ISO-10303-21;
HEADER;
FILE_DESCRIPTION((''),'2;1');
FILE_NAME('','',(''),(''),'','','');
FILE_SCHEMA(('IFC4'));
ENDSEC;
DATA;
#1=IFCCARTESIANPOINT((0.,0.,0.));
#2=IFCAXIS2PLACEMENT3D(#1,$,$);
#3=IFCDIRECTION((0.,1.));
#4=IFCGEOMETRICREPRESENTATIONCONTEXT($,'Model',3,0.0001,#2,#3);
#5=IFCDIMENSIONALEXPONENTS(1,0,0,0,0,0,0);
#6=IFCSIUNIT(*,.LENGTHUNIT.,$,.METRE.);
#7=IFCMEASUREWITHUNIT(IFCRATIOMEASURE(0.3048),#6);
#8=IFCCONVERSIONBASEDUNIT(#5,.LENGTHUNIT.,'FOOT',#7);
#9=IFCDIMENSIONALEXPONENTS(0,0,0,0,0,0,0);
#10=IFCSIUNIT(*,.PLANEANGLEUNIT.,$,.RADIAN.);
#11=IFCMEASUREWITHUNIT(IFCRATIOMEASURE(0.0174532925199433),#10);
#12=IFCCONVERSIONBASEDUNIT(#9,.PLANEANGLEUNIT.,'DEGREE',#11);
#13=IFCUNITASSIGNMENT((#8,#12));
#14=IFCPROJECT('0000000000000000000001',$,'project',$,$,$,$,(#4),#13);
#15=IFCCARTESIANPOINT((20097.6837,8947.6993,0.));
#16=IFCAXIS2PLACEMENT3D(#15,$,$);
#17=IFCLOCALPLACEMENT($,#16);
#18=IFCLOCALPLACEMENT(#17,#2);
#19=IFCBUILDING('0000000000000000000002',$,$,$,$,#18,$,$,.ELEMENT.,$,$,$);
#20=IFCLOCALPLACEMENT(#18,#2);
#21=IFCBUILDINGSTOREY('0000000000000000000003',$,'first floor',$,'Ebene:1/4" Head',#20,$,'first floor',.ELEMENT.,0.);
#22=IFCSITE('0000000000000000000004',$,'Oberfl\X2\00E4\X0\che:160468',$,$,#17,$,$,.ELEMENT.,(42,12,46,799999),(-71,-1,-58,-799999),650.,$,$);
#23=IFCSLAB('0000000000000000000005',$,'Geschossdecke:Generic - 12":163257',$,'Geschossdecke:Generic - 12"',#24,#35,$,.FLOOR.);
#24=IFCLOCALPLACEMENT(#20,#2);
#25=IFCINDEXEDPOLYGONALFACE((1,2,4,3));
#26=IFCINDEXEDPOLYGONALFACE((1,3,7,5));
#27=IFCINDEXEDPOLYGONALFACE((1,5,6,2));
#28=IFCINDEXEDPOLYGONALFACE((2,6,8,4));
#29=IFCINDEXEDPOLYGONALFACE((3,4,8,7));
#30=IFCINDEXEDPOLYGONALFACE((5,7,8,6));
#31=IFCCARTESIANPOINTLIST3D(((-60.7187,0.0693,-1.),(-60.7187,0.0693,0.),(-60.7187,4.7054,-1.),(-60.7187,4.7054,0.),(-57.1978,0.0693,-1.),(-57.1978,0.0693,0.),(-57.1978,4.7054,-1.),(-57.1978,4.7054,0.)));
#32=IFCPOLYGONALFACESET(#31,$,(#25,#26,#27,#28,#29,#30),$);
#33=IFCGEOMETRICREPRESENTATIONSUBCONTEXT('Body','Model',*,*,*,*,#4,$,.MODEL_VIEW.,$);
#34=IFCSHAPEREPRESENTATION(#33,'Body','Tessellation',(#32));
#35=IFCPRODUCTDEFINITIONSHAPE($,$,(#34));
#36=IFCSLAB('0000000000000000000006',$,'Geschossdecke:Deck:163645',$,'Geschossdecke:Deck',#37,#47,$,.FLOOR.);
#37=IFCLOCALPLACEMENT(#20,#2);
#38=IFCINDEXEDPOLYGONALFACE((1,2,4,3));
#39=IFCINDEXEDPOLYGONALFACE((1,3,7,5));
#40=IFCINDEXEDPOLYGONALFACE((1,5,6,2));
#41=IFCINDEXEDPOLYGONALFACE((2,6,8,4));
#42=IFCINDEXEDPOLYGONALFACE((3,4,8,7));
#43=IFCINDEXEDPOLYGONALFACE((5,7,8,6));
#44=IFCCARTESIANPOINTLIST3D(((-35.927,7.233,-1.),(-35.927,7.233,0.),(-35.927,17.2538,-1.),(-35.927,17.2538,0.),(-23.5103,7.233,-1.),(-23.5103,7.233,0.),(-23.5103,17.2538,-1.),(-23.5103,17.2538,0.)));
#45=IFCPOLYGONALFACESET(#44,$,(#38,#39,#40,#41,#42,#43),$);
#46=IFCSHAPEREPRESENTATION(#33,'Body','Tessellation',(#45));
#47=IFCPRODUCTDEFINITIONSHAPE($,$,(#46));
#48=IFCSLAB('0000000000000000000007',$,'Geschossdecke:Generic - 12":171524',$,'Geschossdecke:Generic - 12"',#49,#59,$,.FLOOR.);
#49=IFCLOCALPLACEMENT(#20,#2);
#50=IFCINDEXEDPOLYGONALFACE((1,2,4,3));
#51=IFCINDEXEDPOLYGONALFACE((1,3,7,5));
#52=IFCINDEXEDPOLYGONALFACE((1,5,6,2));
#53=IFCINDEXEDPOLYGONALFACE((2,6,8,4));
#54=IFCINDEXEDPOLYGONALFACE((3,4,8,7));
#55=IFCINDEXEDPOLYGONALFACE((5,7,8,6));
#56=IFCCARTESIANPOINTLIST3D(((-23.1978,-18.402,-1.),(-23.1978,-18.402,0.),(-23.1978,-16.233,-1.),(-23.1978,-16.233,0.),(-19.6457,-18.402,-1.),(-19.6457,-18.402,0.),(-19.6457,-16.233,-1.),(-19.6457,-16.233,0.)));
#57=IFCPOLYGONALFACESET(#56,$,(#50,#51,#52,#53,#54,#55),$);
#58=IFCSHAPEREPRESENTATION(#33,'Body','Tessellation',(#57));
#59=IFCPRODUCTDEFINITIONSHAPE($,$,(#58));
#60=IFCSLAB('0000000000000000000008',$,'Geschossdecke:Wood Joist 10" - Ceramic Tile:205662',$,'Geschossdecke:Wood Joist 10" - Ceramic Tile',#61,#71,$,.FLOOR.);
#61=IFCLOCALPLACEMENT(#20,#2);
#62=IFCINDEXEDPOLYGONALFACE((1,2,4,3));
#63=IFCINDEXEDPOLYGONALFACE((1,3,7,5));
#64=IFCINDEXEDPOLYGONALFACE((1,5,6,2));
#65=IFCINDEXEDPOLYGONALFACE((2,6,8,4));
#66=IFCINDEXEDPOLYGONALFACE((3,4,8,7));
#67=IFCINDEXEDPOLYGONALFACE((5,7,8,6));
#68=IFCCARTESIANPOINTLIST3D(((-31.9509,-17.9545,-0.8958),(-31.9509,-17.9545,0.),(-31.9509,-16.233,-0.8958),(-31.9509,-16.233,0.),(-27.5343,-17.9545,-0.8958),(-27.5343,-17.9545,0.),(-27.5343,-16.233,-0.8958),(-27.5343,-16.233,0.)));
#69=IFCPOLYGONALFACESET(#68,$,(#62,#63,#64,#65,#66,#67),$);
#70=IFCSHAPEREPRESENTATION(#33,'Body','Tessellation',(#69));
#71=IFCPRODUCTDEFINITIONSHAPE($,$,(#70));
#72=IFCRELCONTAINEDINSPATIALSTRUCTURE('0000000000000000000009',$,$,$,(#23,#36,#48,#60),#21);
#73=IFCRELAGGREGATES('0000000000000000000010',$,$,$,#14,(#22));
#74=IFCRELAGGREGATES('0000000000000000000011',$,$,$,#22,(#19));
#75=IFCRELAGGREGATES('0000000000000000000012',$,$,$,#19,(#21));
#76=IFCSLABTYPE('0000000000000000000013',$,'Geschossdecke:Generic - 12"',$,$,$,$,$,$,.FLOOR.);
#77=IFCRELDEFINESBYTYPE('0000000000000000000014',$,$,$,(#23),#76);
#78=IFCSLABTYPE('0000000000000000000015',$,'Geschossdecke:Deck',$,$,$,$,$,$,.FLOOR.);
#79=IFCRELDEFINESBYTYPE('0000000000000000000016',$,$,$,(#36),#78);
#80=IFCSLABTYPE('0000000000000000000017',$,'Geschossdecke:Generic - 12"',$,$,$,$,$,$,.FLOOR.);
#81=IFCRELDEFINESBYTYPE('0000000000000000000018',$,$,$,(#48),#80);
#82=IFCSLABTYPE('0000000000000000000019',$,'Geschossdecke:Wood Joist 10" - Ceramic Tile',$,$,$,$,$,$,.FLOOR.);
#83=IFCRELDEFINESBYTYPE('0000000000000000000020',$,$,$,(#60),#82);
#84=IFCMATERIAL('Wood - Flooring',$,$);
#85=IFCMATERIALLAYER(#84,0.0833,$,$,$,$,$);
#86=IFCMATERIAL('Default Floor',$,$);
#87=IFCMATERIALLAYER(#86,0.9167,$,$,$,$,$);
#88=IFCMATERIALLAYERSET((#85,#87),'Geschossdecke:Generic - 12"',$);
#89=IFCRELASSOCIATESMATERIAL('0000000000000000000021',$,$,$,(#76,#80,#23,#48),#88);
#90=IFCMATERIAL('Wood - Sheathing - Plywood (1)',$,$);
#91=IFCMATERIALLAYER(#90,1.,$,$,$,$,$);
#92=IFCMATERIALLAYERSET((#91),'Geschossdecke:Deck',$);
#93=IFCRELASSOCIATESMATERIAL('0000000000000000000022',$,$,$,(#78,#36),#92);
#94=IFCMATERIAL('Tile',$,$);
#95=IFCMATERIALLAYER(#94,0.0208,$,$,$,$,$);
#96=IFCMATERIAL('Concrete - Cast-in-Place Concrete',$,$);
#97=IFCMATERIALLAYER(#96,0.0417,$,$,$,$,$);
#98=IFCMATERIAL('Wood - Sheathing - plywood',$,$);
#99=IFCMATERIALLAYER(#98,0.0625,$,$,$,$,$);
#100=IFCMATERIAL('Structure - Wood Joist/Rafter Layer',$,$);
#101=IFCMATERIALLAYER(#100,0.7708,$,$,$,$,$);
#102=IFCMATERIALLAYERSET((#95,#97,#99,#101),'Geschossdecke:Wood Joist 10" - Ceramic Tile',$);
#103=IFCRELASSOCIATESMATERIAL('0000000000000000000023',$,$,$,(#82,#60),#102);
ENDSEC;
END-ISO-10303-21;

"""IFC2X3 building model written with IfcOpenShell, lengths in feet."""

from ifc_helpers import new_model, entity, si_unit, converted_unit, direction, frame, frame_2d, origin, origin_2d_with_axis, place, context, subcontext, project, spatial, rectangle, extrude, material, layer, layer_set, layer_usage, type_object, element, save


model = new_model("IFC2X3")

# Units and contexts
model_context = context("Model", 3, precision=0.0001, world=origin(), true_north=direction((0.0, 1.0)))
body_context = subcontext(model_context, "Body", "Model", "MODEL_VIEW")
ifc_project = project(units=[converted_unit("LENGTHUNIT", "FOOT", entity("IfcRatioMeasure", 0.3048), si_unit("LENGTHUNIT", "METRE"), dimensions=[1, 0, 0, 0, 0, 0, 0]), converted_unit("PLANEANGLEUNIT", "DEGREE", entity("IfcRatioMeasure", 0.0174532925199433), si_unit("PLANEANGLEUNIT", "RADIAN"), dimensions=[0, 0, 0, 0, 0, 0, 0])], contexts=[model_context])

# Site, building, storey
site_placement = place(None, frame((20097.6837, 8947.6993, 0.0)))
site = spatial("IfcSite", under=ifc_project, at=site_placement, Name="Oberfläche:160468", CompositionType="ELEMENT", RefLatitude=(42, 12, 46, 799999), RefLongitude=(-71, -1, -58, -799999), RefElevation=650.0)
building_placement = place(site_placement, origin())
building = spatial("IfcBuilding", under=site, at=building_placement, CompositionType="ELEMENT")
storey_placement = place(building_placement, origin())
storey = spatial("IfcBuildingStorey", under=building, at=storey_placement, Name="first floor", ObjectType="Ebene:1/4\" Head", LongName="first floor", CompositionType="ELEMENT", Elevation=0.0)

# Slabs
ifc_material_1 = material(Name="Wood - Flooring")
ifc_layer_1 = layer(ifc_material_1, 0.0833)
ifc_material_2 = material(Name="Default Floor")
ifc_layer_2 = layer(ifc_material_2, 0.9167)
ifc_layer_set_1 = layer_set([ifc_layer_1, ifc_layer_2], Name="Geschossdecke:Generic - 12\"")
ifc_layer_usage_1 = layer_usage(ifc_layer_set_1, "AXIS3", "POSITIVE", 0.0)
slab_type_1 = type_object("IfcSlabType", Name="Geschossdecke:Generic - 12\"", PredefinedType="FLOOR", material=ifc_layer_set_1)
slab_1_placement = place(storey_placement, origin())
element("IfcSlab", 1, at=slab_1_placement, inside=storey, type_object=slab_type_1, material=ifc_layer_usage_1, Name="Geschossdecke:Generic - 12\":163257", ObjectType="Geschossdecke:Generic - 12\"", PredefinedType="FLOOR", context=body_context, shape_type="SweptSolid", body=[
    extrude(rectangle(XDim=4.6361, YDim=3.5208, at=frame_2d((0.0, 0.0), x_axis=(1.0, 0.0))), frame((-58.9582, 2.3874, 0.0), z_axis=(0.0, 0.0, -1.0), x_axis=(0.0, 1.0, 0.0)), (0.0, 0.0, 1.0), 1.0),
])
ifc_material_3 = material(Name="Wood - Sheathing - Plywood (1)")
ifc_layer_3 = layer(ifc_material_3, 1.0)
ifc_layer_set_2 = layer_set([ifc_layer_3], Name="Geschossdecke:Deck")
ifc_layer_usage_2 = layer_usage(ifc_layer_set_2, "AXIS3", "POSITIVE", 0.0)
slab_type_2 = type_object("IfcSlabType", Name="Geschossdecke:Deck", PredefinedType="FLOOR", material=ifc_layer_set_2)
slab_2_placement = place(storey_placement, origin())
element("IfcSlab", 2, at=slab_2_placement, inside=storey, type_object=slab_type_2, material=ifc_layer_usage_2, Name="Geschossdecke:Deck:163645", ObjectType="Geschossdecke:Deck", PredefinedType="FLOOR", context=body_context, shape_type="SweptSolid", body=[
    extrude(rectangle(XDim=10.0208, YDim=12.4167, at=frame_2d((0.0, 0.0), x_axis=(1.0, 0.0))), frame((-29.7187, 12.2434, 0.0), z_axis=(0.0, 0.0, -1.0), x_axis=(0.0, 1.0, 0.0)), (0.0, 0.0, 1.0), 1.0),
])
ifc_layer_usage_3 = layer_usage(ifc_layer_set_1, "AXIS3", "POSITIVE", 0.0)
slab_type_3 = type_object("IfcSlabType", Name="Geschossdecke:Generic - 12\"", PredefinedType="FLOOR", material=ifc_layer_set_1)
slab_3_placement = place(storey_placement, origin())
element("IfcSlab", 3, at=slab_3_placement, inside=storey, type_object=slab_type_3, material=ifc_layer_usage_3, Name="Geschossdecke:Generic - 12\":171524", ObjectType="Geschossdecke:Generic - 12\"", PredefinedType="FLOOR", context=body_context, shape_type="SweptSolid", body=[
    extrude(rectangle(XDim=2.1691, YDim=3.5521, at=origin_2d_with_axis()), frame((-21.4218, -17.3175, 0.0), z_axis=(0.0, 0.0, -1.0), x_axis=(0.0, 1.0, 0.0)), (0.0, 0.0, 1.0), 1.0),
])
ifc_material_4 = material(Name="Tile")
ifc_layer_4 = layer(ifc_material_4, 0.0208)
ifc_material_5 = material(Name="Concrete - Cast-in-Place Concrete")
ifc_layer_5 = layer(ifc_material_5, 0.0417)
ifc_material_6 = material(Name="Wood - Sheathing - plywood")
ifc_layer_6 = layer(ifc_material_6, 0.0625)
ifc_material_7 = material(Name="Structure - Wood Joist/Rafter Layer")
ifc_layer_7 = layer(ifc_material_7, 0.7708)
ifc_layer_set_3 = layer_set([ifc_layer_4, ifc_layer_5, ifc_layer_6, ifc_layer_7], Name="Geschossdecke:Wood Joist 10\" - Ceramic Tile")
ifc_layer_usage_4 = layer_usage(ifc_layer_set_3, "AXIS3", "POSITIVE", 0.0)
slab_type_4 = type_object("IfcSlabType", Name="Geschossdecke:Wood Joist 10\" - Ceramic Tile", PredefinedType="FLOOR", material=ifc_layer_set_3)
slab_4_placement = place(storey_placement, origin())
element("IfcSlab", 4, at=slab_4_placement, inside=storey, type_object=slab_type_4, material=ifc_layer_usage_4, Name="Geschossdecke:Wood Joist 10\" - Ceramic Tile:205662", ObjectType="Geschossdecke:Wood Joist 10\" - Ceramic Tile", PredefinedType="FLOOR", context=body_context, shape_type="SweptSolid", body=[
    extrude(rectangle(XDim=1.7216, YDim=4.4167, at=frame_2d((0.0, 0.0), x_axis=(1.0, 0.0))), frame((-29.7426, -17.0938, 0.0), z_axis=(0.0, 0.0, -1.0), x_axis=(0.0, 1.0, 0.0)), (0.0, 0.0, 1.0), 0.8958),
])

save(model, "model.ifc")
